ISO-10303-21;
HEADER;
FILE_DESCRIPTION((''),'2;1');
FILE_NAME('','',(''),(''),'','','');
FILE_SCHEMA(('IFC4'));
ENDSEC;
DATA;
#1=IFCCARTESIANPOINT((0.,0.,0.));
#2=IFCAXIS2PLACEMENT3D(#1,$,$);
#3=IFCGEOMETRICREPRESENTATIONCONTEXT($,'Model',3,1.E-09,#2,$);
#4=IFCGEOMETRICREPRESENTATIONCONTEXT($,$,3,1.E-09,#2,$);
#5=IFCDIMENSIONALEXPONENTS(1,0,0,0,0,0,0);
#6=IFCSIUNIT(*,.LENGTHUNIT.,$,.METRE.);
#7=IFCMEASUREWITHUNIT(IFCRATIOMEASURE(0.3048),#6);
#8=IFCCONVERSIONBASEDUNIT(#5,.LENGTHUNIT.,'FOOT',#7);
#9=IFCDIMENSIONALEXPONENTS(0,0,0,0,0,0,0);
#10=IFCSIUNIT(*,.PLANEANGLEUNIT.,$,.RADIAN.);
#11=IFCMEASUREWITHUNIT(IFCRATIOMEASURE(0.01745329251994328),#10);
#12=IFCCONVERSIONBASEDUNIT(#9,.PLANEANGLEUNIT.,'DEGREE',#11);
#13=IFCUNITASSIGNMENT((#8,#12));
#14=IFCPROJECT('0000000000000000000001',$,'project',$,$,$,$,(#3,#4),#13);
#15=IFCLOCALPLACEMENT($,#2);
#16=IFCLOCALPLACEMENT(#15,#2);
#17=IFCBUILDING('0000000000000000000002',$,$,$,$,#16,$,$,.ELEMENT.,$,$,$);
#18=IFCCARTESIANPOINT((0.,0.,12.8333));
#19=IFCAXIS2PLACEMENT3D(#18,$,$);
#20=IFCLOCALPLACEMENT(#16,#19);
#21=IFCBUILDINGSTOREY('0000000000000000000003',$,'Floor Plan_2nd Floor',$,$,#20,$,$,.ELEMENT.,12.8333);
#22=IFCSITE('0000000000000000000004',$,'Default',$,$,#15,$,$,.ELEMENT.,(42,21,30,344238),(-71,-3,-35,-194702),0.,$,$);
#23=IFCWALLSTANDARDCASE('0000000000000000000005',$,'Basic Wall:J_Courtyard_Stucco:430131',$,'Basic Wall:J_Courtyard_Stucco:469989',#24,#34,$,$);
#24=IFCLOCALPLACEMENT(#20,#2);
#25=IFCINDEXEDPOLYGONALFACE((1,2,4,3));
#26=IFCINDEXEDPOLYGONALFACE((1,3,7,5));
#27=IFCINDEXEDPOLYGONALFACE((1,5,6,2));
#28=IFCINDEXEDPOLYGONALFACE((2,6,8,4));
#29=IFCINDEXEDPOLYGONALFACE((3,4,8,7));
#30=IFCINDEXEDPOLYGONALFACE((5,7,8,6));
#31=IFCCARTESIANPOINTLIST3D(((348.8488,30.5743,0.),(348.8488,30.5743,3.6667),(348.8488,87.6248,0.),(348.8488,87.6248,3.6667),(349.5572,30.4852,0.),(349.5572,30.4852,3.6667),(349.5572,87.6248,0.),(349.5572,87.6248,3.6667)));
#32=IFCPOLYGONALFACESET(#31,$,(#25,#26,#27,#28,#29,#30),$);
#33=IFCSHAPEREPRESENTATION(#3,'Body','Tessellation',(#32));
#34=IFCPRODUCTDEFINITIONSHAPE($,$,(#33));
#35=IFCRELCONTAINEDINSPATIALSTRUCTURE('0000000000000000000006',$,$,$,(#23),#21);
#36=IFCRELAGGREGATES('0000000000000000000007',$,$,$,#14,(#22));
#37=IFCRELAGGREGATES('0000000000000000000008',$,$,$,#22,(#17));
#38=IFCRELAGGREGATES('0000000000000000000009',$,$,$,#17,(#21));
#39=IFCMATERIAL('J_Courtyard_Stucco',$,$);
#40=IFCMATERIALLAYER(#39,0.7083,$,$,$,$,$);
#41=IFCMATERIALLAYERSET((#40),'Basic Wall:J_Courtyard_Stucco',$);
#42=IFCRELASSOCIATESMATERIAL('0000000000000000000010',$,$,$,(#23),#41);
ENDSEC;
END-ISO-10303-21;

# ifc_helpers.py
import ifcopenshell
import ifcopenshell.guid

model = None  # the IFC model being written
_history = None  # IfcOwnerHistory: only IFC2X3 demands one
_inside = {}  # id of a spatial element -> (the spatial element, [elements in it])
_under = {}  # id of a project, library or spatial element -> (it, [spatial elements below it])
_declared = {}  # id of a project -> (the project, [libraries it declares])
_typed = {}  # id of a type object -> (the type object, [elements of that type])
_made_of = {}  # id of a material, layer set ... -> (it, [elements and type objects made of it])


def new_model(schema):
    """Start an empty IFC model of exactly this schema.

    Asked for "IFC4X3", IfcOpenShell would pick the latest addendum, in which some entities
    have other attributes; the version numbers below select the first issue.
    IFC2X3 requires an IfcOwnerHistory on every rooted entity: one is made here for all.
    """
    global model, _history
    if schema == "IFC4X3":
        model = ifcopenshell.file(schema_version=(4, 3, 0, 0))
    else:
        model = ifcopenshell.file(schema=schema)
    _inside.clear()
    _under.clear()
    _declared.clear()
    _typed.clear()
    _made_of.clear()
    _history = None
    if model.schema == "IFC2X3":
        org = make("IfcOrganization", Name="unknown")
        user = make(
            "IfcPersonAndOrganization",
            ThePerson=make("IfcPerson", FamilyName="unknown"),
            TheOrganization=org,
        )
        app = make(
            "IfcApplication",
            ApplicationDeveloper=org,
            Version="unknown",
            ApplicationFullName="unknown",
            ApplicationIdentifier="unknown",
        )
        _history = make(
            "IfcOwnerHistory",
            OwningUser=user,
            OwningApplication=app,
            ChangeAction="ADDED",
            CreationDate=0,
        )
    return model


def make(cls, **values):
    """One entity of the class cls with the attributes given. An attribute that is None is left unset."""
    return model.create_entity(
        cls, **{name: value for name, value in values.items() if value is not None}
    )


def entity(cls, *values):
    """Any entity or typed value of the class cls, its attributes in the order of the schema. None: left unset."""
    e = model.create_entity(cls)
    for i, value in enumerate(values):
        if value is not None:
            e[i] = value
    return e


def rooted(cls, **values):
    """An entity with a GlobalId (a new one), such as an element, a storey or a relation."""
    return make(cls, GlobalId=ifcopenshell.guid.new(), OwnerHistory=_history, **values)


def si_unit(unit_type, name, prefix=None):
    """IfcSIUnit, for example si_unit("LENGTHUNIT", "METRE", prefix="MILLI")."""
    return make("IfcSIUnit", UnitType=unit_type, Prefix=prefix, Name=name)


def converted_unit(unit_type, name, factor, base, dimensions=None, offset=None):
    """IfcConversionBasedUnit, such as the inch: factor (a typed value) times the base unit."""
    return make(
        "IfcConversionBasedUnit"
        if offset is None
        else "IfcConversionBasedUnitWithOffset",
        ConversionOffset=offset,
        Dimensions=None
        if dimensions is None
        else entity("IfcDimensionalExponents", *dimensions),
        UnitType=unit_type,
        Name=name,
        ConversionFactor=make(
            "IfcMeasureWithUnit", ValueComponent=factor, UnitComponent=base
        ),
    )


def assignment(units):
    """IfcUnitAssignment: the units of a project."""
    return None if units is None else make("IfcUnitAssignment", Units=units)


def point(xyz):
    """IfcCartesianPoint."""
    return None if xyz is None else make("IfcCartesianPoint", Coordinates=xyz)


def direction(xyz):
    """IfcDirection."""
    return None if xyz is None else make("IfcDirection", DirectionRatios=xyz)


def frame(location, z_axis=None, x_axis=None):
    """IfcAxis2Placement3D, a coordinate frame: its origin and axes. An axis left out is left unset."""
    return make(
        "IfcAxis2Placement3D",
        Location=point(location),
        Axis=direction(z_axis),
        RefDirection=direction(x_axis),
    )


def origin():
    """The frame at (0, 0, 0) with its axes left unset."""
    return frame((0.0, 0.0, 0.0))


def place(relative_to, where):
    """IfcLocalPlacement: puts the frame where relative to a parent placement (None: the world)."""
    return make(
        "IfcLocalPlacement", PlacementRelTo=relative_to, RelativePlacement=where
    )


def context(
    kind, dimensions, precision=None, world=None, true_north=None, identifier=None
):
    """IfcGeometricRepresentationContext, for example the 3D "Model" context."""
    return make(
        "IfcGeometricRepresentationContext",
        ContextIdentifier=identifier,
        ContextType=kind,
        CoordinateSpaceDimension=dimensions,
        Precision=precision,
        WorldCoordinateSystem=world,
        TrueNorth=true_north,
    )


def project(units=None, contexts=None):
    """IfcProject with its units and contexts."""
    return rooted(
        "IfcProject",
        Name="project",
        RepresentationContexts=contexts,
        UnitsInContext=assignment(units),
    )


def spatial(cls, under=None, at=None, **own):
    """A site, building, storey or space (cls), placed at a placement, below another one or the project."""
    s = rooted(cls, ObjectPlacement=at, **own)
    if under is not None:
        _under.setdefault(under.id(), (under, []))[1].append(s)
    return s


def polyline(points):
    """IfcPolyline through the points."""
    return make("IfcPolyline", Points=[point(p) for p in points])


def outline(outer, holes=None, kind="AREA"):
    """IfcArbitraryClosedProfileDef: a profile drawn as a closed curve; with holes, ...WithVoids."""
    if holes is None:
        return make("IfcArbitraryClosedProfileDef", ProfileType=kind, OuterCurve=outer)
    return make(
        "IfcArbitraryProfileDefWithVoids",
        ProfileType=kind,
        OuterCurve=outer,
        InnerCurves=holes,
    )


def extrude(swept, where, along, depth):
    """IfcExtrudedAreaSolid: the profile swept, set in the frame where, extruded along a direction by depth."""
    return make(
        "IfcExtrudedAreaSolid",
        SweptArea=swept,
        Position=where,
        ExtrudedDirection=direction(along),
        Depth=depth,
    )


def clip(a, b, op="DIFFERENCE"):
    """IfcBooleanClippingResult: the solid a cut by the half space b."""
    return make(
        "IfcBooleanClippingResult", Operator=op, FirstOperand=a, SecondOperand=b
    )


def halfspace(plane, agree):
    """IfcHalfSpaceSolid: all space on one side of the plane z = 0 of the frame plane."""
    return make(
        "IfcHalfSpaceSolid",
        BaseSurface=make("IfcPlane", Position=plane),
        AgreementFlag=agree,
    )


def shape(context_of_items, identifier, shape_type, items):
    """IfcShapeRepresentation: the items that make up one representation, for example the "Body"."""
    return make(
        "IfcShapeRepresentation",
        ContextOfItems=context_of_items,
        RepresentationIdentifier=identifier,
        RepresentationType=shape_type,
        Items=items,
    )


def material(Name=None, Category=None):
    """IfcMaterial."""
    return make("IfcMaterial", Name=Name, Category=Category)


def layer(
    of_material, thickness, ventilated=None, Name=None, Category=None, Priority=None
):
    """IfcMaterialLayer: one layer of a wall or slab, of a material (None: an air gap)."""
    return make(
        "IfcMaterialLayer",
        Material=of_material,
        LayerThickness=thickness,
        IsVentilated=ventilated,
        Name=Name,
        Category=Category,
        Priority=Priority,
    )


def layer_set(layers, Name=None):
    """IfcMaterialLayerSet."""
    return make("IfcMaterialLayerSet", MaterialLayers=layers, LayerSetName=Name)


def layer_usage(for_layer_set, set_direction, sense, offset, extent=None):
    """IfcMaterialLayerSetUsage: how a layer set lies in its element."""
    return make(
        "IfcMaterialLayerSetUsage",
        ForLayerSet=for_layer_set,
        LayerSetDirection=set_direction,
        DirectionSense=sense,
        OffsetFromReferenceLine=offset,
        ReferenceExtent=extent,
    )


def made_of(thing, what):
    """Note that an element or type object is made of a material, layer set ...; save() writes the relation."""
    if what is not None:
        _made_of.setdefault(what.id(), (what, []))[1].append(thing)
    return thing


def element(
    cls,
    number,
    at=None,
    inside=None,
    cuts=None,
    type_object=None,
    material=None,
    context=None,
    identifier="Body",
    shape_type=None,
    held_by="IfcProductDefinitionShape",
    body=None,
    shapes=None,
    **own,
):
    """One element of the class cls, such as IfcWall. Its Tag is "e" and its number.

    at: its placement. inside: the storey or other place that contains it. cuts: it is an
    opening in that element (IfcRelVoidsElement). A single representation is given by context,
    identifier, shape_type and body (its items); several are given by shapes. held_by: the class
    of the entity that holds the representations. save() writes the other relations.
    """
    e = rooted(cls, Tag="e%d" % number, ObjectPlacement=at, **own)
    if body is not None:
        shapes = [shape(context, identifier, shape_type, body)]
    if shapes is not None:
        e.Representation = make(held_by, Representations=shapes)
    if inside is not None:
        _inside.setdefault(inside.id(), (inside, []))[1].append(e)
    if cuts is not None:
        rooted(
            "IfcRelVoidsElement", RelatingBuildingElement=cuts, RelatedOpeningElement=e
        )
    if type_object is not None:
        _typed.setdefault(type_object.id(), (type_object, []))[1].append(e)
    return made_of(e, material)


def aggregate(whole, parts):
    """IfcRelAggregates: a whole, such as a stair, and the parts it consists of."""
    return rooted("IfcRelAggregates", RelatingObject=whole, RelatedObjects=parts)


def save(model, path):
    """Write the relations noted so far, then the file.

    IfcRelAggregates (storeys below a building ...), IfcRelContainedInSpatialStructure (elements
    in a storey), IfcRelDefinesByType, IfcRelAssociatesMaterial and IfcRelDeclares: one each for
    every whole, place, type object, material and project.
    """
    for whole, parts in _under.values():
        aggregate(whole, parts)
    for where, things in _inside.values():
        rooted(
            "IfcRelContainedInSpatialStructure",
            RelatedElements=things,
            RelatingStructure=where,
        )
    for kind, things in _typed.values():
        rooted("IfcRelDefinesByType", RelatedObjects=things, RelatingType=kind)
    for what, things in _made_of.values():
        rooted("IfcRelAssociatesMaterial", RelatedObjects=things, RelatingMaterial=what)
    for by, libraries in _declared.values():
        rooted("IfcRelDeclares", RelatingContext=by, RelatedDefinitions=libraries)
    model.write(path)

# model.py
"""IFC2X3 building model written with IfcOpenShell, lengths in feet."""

from ifc_helpers import new_model, entity, si_unit, converted_unit, frame, origin, place, context, project, spatial, polyline, outline, extrude, clip, halfspace, material, layer, layer_set, layer_usage, element, save


model = new_model("IFC2X3")

# Units and contexts
model_context = context("Model", 3, precision=1e-09, world=origin())
context_of_model = context(None, 3, precision=1e-09, world=origin())
ifc_project = project(units=[converted_unit("LENGTHUNIT", "FOOT", entity("IfcRatioMeasure", 0.3048), si_unit("LENGTHUNIT", "METRE"), dimensions=[1, 0, 0, 0, 0, 0, 0]), converted_unit("PLANEANGLEUNIT", "DEGREE", entity("IfcRatioMeasure", 0.01745329251994328), si_unit("PLANEANGLEUNIT", "RADIAN"), dimensions=[0, 0, 0, 0, 0, 0, 0])], contexts=[model_context, context_of_model])

# Site, building, storey
site_placement = place(None, origin())
site = spatial("IfcSite", under=ifc_project, at=site_placement, Name="Default", CompositionType="ELEMENT", RefLatitude=(42, 21, 30, 344238), RefLongitude=(-71, -3, -35, -194702), RefElevation=0.0)
building_placement = place(site_placement, origin())
building = spatial("IfcBuilding", under=site, at=building_placement, CompositionType="ELEMENT")
storey_placement = place(building_placement, frame((0.0, 0.0, 12.8333)))
storey = spatial("IfcBuildingStorey", under=building, at=storey_placement, Name="Floor Plan_2nd Floor", CompositionType="ELEMENT", Elevation=12.8333)

# Wall
ifc_material_1 = material(Name="J_Courtyard_Stucco")
ifc_layer_1 = layer(ifc_material_1, 0.7083)
ifc_layer_set_1 = layer_set([ifc_layer_1], Name="Basic Wall:J_Courtyard_Stucco")
ifc_layer_usage_1 = layer_usage(ifc_layer_set_1, "AXIS2", "NEGATIVE", 0.3542)
wall_1_placement = place(storey_placement, frame((349.203, 30.4852, 0.0), z_axis=(0.0, 0.0, 1.0), x_axis=(0.0, 1.0, 0.0)))
element("IfcWallStandardCase", 1, at=wall_1_placement, inside=storey, material=ifc_layer_usage_1, Name="Basic Wall:J_Courtyard_Stucco:430131", ObjectType="Basic Wall:J_Courtyard_Stucco:469989", context=model_context, shape_type="Clipping", body=[
    clip(extrude(outline(polyline([(57.1396, -0.3542), (57.1396, 0.3542), (0.0891, 0.3542), (0.0, -0.3542), (57.1396, -0.3542)])), origin(), (0.0, 0.0, 1.0), 3.6667), halfspace(frame((0.0, 0.0, -12.6667)), True)),
])

save(model, "model.ifc")
